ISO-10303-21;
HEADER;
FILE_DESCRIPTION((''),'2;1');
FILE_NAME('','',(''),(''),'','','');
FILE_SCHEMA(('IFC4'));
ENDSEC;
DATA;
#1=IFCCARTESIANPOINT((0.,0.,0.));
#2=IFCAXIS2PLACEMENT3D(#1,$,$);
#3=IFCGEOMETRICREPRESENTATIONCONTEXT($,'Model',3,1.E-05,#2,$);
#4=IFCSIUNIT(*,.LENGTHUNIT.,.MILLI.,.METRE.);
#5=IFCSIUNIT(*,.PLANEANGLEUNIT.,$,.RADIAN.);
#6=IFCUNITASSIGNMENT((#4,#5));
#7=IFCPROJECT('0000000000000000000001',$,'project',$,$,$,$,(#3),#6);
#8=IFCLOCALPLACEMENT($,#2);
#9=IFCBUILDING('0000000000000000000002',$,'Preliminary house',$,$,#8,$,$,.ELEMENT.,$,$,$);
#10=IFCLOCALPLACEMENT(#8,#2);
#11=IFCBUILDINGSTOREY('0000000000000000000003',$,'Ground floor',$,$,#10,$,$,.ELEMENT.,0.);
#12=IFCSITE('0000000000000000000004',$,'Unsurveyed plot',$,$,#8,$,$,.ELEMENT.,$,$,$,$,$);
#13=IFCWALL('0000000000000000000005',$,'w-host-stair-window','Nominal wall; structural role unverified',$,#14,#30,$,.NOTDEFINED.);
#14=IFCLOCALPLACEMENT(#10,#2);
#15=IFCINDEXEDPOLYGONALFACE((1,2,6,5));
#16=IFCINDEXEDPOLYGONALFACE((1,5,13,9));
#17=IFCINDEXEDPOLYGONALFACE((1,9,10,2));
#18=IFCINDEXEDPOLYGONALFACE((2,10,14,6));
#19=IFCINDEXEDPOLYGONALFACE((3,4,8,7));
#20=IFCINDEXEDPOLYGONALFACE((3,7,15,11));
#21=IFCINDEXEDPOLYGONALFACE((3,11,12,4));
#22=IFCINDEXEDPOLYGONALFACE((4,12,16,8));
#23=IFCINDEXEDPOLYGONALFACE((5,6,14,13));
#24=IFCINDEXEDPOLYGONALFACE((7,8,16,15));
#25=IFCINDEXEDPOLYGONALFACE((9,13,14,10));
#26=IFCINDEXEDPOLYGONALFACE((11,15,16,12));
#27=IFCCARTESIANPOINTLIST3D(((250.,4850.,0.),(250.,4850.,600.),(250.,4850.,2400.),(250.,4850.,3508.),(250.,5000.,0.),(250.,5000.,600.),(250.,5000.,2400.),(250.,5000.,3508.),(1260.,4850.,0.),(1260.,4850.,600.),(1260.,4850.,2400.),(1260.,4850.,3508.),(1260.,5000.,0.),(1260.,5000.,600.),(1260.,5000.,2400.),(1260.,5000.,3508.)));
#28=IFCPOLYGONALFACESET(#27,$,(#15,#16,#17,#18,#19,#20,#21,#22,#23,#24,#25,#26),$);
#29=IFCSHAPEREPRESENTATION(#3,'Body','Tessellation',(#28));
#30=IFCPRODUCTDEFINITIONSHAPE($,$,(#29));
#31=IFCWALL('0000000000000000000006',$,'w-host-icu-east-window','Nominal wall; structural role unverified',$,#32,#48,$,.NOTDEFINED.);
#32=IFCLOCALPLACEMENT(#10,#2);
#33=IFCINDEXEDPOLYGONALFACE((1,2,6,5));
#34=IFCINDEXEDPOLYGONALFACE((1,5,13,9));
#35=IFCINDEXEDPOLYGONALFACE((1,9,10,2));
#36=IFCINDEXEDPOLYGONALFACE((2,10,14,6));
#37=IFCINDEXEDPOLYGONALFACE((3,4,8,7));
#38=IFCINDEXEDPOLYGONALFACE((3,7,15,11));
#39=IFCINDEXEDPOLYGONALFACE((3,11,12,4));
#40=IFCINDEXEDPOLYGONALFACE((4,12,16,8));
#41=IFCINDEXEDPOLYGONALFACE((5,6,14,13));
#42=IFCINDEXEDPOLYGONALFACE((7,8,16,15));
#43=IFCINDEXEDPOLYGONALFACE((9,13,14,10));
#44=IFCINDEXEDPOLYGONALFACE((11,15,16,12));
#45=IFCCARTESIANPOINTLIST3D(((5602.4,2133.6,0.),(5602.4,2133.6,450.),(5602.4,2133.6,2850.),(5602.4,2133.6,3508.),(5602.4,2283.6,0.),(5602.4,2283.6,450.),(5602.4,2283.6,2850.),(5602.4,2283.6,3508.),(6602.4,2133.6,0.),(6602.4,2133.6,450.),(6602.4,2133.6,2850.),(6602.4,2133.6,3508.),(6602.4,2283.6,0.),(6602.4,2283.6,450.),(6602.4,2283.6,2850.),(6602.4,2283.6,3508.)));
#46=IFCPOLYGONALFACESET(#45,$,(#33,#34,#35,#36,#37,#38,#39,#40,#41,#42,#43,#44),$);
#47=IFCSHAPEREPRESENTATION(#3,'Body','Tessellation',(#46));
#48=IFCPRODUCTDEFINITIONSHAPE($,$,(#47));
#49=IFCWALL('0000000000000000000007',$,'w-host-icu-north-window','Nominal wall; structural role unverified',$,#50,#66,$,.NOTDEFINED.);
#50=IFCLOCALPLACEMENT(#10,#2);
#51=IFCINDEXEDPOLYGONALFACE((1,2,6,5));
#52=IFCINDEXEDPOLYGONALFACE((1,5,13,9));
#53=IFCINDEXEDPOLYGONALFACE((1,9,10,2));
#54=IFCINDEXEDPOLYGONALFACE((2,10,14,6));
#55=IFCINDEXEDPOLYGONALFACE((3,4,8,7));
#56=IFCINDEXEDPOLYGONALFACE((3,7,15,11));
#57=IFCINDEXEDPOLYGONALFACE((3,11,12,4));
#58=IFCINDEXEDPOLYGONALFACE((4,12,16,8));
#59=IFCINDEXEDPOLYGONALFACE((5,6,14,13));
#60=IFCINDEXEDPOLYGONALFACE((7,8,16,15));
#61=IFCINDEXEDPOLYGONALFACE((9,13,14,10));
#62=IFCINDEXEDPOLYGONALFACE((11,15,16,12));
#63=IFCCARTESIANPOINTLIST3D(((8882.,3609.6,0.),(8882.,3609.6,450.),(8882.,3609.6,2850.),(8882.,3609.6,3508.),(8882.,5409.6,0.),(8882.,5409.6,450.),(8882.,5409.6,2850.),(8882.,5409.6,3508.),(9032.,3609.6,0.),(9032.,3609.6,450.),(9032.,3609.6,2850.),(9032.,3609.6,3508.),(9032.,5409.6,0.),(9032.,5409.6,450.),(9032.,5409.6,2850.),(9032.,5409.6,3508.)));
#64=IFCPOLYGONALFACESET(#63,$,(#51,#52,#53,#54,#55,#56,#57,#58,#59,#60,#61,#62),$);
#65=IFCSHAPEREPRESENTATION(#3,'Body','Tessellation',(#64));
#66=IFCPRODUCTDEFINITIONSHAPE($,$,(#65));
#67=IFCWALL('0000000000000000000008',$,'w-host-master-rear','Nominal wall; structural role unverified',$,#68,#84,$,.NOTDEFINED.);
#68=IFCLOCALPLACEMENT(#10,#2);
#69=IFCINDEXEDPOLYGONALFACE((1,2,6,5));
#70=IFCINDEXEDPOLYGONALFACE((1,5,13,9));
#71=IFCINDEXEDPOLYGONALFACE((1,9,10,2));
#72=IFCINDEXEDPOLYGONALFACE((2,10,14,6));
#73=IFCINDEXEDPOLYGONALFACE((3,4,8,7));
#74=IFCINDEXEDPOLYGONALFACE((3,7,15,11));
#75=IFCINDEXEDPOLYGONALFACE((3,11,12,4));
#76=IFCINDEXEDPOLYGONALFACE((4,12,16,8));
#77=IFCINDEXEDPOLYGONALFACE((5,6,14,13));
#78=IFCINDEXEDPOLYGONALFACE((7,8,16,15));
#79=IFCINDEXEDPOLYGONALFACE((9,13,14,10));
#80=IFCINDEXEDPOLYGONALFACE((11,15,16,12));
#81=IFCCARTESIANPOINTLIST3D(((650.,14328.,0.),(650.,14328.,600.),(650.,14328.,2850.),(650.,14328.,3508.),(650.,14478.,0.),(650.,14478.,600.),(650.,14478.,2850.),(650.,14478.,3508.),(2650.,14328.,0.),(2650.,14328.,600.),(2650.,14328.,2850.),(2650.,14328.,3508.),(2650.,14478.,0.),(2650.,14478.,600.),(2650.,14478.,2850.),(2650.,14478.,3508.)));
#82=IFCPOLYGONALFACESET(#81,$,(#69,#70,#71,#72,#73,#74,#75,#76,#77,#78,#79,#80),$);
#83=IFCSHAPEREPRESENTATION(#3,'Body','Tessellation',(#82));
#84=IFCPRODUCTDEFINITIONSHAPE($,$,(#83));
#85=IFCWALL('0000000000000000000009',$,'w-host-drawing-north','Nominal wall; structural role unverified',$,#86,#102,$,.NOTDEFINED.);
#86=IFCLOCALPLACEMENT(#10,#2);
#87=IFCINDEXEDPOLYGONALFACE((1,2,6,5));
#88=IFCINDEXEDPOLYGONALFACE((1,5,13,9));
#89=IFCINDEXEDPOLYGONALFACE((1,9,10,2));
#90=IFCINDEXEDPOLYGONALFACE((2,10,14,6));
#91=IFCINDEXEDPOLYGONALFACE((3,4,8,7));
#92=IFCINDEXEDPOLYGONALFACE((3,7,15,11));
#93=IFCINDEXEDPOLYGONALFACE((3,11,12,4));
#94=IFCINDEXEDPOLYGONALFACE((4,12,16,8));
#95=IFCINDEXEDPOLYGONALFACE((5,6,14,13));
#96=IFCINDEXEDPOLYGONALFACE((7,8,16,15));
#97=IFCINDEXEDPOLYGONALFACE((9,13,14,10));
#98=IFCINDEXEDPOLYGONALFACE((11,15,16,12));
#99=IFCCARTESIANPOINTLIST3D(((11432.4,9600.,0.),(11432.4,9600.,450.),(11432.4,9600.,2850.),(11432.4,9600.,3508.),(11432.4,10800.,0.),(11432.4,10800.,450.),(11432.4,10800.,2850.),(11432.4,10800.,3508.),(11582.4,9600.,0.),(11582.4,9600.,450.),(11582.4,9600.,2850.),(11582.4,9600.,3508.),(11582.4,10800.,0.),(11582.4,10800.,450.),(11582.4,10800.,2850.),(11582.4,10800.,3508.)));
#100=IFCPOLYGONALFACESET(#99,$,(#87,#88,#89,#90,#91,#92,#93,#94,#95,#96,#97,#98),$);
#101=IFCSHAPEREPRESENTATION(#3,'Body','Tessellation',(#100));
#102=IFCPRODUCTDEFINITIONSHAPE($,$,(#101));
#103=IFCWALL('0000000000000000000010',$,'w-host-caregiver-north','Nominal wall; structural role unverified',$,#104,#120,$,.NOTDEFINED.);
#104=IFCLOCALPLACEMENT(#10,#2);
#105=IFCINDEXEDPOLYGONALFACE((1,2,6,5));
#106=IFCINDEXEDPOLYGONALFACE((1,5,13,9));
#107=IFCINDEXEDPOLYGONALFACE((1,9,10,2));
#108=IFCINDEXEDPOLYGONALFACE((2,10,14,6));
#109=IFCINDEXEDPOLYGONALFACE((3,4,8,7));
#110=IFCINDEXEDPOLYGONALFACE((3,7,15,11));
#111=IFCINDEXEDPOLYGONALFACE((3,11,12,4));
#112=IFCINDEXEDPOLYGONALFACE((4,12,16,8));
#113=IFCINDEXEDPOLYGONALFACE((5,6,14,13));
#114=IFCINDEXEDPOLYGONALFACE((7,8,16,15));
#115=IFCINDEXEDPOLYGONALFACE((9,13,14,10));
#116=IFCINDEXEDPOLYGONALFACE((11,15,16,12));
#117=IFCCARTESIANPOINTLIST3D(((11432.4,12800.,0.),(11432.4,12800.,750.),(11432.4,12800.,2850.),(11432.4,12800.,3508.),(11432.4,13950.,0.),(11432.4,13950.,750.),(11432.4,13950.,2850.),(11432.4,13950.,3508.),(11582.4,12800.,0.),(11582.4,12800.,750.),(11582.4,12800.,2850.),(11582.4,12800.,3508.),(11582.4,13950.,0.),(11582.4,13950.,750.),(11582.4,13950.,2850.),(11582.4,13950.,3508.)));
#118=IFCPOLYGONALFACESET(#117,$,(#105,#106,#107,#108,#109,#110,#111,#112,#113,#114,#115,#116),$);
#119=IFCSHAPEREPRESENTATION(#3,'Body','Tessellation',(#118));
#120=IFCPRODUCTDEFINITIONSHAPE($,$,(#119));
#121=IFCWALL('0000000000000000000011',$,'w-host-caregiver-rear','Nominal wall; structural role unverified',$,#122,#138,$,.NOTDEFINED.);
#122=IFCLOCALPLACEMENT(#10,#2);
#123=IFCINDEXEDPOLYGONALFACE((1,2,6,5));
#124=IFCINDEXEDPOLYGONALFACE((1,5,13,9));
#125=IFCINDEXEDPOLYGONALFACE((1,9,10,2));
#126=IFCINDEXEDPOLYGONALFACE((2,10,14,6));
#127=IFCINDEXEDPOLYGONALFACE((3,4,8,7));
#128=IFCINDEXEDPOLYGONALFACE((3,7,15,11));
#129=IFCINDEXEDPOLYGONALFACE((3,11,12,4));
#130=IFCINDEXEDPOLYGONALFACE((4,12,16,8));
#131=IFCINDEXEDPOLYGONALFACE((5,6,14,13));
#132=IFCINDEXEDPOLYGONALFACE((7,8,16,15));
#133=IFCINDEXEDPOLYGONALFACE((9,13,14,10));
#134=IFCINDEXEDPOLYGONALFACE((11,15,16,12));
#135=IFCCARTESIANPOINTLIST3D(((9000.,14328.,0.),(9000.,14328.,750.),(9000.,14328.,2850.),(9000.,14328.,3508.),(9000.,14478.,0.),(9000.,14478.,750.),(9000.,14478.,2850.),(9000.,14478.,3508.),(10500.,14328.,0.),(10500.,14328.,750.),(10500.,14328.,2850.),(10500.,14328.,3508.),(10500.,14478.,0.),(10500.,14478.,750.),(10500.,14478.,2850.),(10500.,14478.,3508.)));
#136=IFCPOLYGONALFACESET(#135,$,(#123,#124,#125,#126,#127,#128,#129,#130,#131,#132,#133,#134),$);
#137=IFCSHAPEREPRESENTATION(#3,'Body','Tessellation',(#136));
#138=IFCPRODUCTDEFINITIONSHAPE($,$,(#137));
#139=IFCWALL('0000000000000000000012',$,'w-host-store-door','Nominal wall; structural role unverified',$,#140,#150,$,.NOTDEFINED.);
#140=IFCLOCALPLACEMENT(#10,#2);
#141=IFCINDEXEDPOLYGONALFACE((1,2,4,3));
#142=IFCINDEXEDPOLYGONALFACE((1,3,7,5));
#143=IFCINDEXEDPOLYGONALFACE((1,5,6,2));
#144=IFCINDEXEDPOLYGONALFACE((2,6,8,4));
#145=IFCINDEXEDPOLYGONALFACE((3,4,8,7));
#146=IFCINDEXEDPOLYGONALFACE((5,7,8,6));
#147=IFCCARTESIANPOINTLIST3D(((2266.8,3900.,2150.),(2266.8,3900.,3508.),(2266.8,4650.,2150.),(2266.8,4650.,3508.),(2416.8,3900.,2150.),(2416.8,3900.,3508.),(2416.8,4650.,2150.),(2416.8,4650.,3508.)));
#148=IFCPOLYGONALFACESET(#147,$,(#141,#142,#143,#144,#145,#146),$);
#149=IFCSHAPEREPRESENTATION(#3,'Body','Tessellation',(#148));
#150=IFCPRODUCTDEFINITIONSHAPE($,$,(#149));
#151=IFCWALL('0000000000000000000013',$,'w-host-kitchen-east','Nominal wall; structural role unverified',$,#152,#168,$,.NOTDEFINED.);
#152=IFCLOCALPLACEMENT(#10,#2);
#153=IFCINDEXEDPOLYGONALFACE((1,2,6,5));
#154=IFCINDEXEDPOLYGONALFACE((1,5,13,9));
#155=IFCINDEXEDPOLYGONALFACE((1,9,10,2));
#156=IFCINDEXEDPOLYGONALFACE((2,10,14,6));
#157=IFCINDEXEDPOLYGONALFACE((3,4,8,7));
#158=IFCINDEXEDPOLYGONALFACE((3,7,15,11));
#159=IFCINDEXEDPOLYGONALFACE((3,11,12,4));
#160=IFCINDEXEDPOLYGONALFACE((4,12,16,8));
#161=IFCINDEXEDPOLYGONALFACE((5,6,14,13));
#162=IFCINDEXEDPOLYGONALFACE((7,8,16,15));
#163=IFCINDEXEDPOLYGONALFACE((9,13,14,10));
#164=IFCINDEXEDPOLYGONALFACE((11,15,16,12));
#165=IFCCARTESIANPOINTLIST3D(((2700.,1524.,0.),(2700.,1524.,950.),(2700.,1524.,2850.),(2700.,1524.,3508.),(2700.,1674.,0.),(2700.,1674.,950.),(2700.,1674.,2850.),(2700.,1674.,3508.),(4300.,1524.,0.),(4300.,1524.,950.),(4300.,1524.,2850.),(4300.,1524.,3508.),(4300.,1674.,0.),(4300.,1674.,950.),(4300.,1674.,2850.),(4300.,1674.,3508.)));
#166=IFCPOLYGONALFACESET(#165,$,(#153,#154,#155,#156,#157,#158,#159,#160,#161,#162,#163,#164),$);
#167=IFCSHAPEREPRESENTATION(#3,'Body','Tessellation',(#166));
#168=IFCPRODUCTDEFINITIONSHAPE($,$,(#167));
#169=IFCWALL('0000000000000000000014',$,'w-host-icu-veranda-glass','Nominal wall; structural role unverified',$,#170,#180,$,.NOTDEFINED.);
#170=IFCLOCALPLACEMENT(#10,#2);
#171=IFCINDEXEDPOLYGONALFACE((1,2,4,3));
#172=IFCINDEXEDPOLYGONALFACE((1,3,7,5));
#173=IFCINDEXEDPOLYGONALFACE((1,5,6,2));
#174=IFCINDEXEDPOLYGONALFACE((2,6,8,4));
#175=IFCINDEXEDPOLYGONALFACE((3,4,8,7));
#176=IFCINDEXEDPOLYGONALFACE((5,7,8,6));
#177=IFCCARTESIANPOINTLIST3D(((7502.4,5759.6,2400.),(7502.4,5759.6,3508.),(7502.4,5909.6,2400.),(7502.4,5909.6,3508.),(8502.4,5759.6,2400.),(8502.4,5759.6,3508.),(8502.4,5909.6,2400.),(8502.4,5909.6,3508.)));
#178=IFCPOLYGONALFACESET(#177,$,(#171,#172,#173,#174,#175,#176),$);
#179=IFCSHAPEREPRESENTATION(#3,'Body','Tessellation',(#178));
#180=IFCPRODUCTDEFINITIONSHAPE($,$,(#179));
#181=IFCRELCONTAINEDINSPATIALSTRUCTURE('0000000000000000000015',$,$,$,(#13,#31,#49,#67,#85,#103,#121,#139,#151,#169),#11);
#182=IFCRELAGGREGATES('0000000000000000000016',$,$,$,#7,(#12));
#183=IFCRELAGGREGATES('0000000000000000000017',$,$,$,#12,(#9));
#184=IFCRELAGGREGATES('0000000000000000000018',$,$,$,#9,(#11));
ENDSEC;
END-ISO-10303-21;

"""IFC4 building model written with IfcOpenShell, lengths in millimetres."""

from ifc_helpers import new_model, si_unit, frame, origin, place, context, project, spatial, polyline, outline, extrude, element, save


model = new_model("IFC4")

# Units and contexts
model_context = context("Model", 3, precision=1e-05, world=origin())
ifc_project = project(units=[si_unit("LENGTHUNIT", "METRE", prefix="MILLI"), si_unit("PLANEANGLEUNIT", "RADIAN")], contexts=[model_context])

# Site, building, storey
placement_1 = place(None, origin())
site = spatial("IfcSite", under=ifc_project, at=placement_1, Name="Unsurveyed plot", CompositionType="ELEMENT")
building = spatial("IfcBuilding", under=site, at=placement_1, Name="Preliminary house", CompositionType="ELEMENT")
placement_2 = place(placement_1, origin())
storey = spatial("IfcBuildingStorey", under=building, at=placement_2, Name="Ground floor", CompositionType="ELEMENT", Elevation=0.0)

# Walls, openings
wall_1 = element("IfcWall", 1, at=placement_2, inside=storey, Name="w-host-stair-window", Description="Nominal wall; structural role unverified", PredefinedType="NOTDEFINED", context=model_context, shape_type="SweptSolid", body=[
    extrude(outline(polyline([(250.0, 4850.0), (1260.0, 4850.0), (1260.0, 5000.0), (250.0, 5000.0), (250.0, 4850.0)])), origin(), (0.0, 0.0, 1.0), 3508.0),
])
element("IfcOpeningElement", 2, at=placement_2, cuts=wall_1, PredefinedType="OPENING", context=model_context, shape_type="SweptSolid", body=[
    extrude(outline(polyline([(250.0, 4475.0), (1260.0, 4475.0), (1260.0, 5375.0), (250.0, 5375.0), (250.0, 4475.0)])), frame((0.0, 0.0, 600.0)), (0.0, 0.0, 1.0), 1800.0),
])
wall_2 = element("IfcWall", 3, at=placement_2, inside=storey, Name="w-host-icu-east-window", Description="Nominal wall; structural role unverified", PredefinedType="NOTDEFINED", context=model_context, shape_type="SweptSolid", body=[
    extrude(outline(polyline([(5602.4, 2133.6), (6602.4, 2133.6), (6602.4, 2283.6), (5602.4, 2283.6), (5602.4, 2133.6)])), origin(), (0.0, 0.0, 1.0), 3508.0),
])
element("IfcOpeningElement", 4, at=placement_2, cuts=wall_2, PredefinedType="OPENING", context=model_context, shape_type="SweptSolid", body=[
    extrude(outline(polyline([(5602.4, 1758.6), (6602.4, 1758.6), (6602.4, 2658.6), (5602.4, 2658.6), (5602.4, 1758.6)])), frame((0.0, 0.0, 450.0)), (0.0, 0.0, 1.0), 2400.0),
])
wall_3 = element("IfcWall", 5, at=placement_2, inside=storey, Name="w-host-icu-north-window", Description="Nominal wall; structural role unverified", PredefinedType="NOTDEFINED", context=model_context, shape_type="SweptSolid", body=[
    extrude(outline(polyline([(9032.0, 3609.6), (9032.0, 5409.6), (8882.0, 5409.6), (8882.0, 3609.6), (9032.0, 3609.6)])), origin(), (0.0, 0.0, 1.0), 3508.0),
])
element("IfcOpeningElement", 6, at=placement_2, cuts=wall_3, PredefinedType="OPENING", context=model_context, shape_type="SweptSolid", body=[
    extrude(outline(polyline([(9407.0, 3609.6), (9407.0, 5409.6), (8507.0, 5409.6), (8507.0, 3609.6), (9407.0, 3609.6)])), frame((0.0, 0.0, 450.0)), (0.0, 0.0, 1.0), 2400.0),
])
wall_4 = element("IfcWall", 7, at=placement_2, inside=storey, Name="w-host-master-rear", Description="Nominal wall; structural role unverified", PredefinedType="NOTDEFINED", context=model_context, shape_type="SweptSolid", body=[
    extrude(outline(polyline([(650.0, 14328.0), (2650.0, 14328.0), (2650.0, 14478.0), (650.0, 14478.0), (650.0, 14328.0)])), origin(), (0.0, 0.0, 1.0), 3508.0),
])
element("IfcOpeningElement", 8, at=placement_2, cuts=wall_4, PredefinedType="OPENING", context=model_context, shape_type="SweptSolid", body=[
    extrude(outline(polyline([(650.0, 13953.0), (2650.0, 13953.0), (2650.0, 14853.0), (650.0, 14853.0), (650.0, 13953.0)])), frame((0.0, 0.0, 600.0)), (0.0, 0.0, 1.0), 2250.0),
])
wall_5 = element("IfcWall", 9, at=placement_2, inside=storey, Name="w-host-drawing-north", Description="Nominal wall; structural role unverified", PredefinedType="NOTDEFINED", context=model_context, shape_type="SweptSolid", body=[
    extrude(outline(polyline([(11582.4, 9600.0), (11582.4, 10800.0), (11432.4, 10800.0), (11432.4, 9600.0), (11582.4, 9600.0)])), origin(), (0.0, 0.0, 1.0), 3508.0),
])
element("IfcOpeningElement", 10, at=placement_2, cuts=wall_5, PredefinedType="OPENING", context=model_context, shape_type="SweptSolid", body=[
    extrude(outline(polyline([(11957.4, 9600.0), (11957.4, 10800.0), (11057.4, 10800.0), (11057.4, 9600.0), (11957.4, 9600.0)])), frame((0.0, 0.0, 450.0)), (0.0, 0.0, 1.0), 2400.0),
])
wall_6 = element("IfcWall", 11, at=placement_2, inside=storey, Name="w-host-caregiver-north", Description="Nominal wall; structural role unverified", PredefinedType="NOTDEFINED", context=model_context, shape_type="SweptSolid", body=[
    extrude(outline(polyline([(11582.4, 12800.0), (11582.4, 13950.0), (11432.4, 13950.0), (11432.4, 12800.0), (11582.4, 12800.0)])), origin(), (0.0, 0.0, 1.0), 3508.0),
])
element("IfcOpeningElement", 12, at=placement_2, cuts=wall_6, PredefinedType="OPENING", context=model_context, shape_type="SweptSolid", body=[
    extrude(outline(polyline([(11957.4, 12800.0), (11957.4, 13950.0), (11057.4, 13950.0), (11057.4, 12800.0), (11957.4, 12800.0)])), frame((0.0, 0.0, 750.0)), (0.0, 0.0, 1.0), 2100.0),
])
wall_7 = element("IfcWall", 13, at=placement_2, inside=storey, Name="w-host-caregiver-rear", Description="Nominal wall; structural role unverified", PredefinedType="NOTDEFINED", context=model_context, shape_type="SweptSolid", body=[
    extrude(outline(polyline([(9000.0, 14328.0), (10500.0, 14328.0), (10500.0, 14478.0), (9000.0, 14478.0), (9000.0, 14328.0)])), origin(), (0.0, 0.0, 1.0), 3508.0),
])
element("IfcOpeningElement", 14, at=placement_2, cuts=wall_7, PredefinedType="OPENING", context=model_context, shape_type="SweptSolid", body=[
    extrude(outline(polyline([(9000.0, 13953.0), (10500.0, 13953.0), (10500.0, 14853.0), (9000.0, 14853.0), (9000.0, 13953.0)])), frame((0.0, 0.0, 750.0)), (0.0, 0.0, 1.0), 2100.0),
])
wall_8 = element("IfcWall", 15, at=placement_2, inside=storey, Name="w-host-store-door", Description="Nominal wall; structural role unverified", PredefinedType="NOTDEFINED", context=model_context, shape_type="SweptSolid", body=[
    extrude(outline(polyline([(2416.8, 3900.0), (2416.8, 4650.0), (2266.8, 4650.0), (2266.8, 3900.0), (2416.8, 3900.0)])), origin(), (0.0, 0.0, 1.0), 3508.0),
])
element("IfcOpeningElement", 16, at=placement_2, cuts=wall_8, PredefinedType="OPENING", context=model_context, shape_type="SweptSolid", body=[
    extrude(outline(polyline([(2791.8, 3900.0), (2791.8, 4650.0), (1891.8, 4650.0), (1891.8, 3900.0), (2791.8, 3900.0)])), origin(), (0.0, 0.0, 1.0), 2150.0),
])
wall_9 = element("IfcWall", 17, at=placement_2, inside=storey, Name="w-host-kitchen-east", Description="Nominal wall; structural role unverified", PredefinedType="NOTDEFINED", context=model_context, shape_type="SweptSolid", body=[
    extrude(outline(polyline([(2700.0, 1524.0), (4300.0, 1524.0), (4300.0, 1674.0), (2700.0, 1674.0), (2700.0, 1524.0)])), origin(), (0.0, 0.0, 1.0), 3508.0),
])
element("IfcOpeningElement", 18, at=placement_2, cuts=wall_9, PredefinedType="OPENING", context=model_context, shape_type="SweptSolid", body=[
    extrude(outline(polyline([(2700.0, 1149.0), (4300.0, 1149.0), (4300.0, 2049.0), (2700.0, 2049.0), (2700.0, 1149.0)])), frame((0.0, 0.0, 950.0)), (0.0, 0.0, 1.0), 1900.0),
])
wall_10 = element("IfcWall", 19, at=placement_2, inside=storey, Name="w-host-icu-veranda-glass", Description="Nominal wall; structural role unverified", PredefinedType="NOTDEFINED", context=model_context, shape_type="SweptSolid", body=[
    extrude(outline(polyline([(7502.4, 5759.6), (8502.4, 5759.6), (8502.4, 5909.6), (7502.4, 5909.6), (7502.4, 5759.6)])), origin(), (0.0, 0.0, 1.0), 3508.0),
])
element("IfcOpeningElement", 20, at=placement_2, cuts=wall_10, PredefinedType="OPENING", context=model_context, shape_type="SweptSolid", body=[
    extrude(outline(polyline([(7502.4, 5384.6), (8502.4, 5384.6), (8502.4, 6284.6), (7502.4, 6284.6), (7502.4, 5384.6)])), origin(), (0.0, 0.0, 1.0), 2400.0),
])

save(model, "model.ifc")
